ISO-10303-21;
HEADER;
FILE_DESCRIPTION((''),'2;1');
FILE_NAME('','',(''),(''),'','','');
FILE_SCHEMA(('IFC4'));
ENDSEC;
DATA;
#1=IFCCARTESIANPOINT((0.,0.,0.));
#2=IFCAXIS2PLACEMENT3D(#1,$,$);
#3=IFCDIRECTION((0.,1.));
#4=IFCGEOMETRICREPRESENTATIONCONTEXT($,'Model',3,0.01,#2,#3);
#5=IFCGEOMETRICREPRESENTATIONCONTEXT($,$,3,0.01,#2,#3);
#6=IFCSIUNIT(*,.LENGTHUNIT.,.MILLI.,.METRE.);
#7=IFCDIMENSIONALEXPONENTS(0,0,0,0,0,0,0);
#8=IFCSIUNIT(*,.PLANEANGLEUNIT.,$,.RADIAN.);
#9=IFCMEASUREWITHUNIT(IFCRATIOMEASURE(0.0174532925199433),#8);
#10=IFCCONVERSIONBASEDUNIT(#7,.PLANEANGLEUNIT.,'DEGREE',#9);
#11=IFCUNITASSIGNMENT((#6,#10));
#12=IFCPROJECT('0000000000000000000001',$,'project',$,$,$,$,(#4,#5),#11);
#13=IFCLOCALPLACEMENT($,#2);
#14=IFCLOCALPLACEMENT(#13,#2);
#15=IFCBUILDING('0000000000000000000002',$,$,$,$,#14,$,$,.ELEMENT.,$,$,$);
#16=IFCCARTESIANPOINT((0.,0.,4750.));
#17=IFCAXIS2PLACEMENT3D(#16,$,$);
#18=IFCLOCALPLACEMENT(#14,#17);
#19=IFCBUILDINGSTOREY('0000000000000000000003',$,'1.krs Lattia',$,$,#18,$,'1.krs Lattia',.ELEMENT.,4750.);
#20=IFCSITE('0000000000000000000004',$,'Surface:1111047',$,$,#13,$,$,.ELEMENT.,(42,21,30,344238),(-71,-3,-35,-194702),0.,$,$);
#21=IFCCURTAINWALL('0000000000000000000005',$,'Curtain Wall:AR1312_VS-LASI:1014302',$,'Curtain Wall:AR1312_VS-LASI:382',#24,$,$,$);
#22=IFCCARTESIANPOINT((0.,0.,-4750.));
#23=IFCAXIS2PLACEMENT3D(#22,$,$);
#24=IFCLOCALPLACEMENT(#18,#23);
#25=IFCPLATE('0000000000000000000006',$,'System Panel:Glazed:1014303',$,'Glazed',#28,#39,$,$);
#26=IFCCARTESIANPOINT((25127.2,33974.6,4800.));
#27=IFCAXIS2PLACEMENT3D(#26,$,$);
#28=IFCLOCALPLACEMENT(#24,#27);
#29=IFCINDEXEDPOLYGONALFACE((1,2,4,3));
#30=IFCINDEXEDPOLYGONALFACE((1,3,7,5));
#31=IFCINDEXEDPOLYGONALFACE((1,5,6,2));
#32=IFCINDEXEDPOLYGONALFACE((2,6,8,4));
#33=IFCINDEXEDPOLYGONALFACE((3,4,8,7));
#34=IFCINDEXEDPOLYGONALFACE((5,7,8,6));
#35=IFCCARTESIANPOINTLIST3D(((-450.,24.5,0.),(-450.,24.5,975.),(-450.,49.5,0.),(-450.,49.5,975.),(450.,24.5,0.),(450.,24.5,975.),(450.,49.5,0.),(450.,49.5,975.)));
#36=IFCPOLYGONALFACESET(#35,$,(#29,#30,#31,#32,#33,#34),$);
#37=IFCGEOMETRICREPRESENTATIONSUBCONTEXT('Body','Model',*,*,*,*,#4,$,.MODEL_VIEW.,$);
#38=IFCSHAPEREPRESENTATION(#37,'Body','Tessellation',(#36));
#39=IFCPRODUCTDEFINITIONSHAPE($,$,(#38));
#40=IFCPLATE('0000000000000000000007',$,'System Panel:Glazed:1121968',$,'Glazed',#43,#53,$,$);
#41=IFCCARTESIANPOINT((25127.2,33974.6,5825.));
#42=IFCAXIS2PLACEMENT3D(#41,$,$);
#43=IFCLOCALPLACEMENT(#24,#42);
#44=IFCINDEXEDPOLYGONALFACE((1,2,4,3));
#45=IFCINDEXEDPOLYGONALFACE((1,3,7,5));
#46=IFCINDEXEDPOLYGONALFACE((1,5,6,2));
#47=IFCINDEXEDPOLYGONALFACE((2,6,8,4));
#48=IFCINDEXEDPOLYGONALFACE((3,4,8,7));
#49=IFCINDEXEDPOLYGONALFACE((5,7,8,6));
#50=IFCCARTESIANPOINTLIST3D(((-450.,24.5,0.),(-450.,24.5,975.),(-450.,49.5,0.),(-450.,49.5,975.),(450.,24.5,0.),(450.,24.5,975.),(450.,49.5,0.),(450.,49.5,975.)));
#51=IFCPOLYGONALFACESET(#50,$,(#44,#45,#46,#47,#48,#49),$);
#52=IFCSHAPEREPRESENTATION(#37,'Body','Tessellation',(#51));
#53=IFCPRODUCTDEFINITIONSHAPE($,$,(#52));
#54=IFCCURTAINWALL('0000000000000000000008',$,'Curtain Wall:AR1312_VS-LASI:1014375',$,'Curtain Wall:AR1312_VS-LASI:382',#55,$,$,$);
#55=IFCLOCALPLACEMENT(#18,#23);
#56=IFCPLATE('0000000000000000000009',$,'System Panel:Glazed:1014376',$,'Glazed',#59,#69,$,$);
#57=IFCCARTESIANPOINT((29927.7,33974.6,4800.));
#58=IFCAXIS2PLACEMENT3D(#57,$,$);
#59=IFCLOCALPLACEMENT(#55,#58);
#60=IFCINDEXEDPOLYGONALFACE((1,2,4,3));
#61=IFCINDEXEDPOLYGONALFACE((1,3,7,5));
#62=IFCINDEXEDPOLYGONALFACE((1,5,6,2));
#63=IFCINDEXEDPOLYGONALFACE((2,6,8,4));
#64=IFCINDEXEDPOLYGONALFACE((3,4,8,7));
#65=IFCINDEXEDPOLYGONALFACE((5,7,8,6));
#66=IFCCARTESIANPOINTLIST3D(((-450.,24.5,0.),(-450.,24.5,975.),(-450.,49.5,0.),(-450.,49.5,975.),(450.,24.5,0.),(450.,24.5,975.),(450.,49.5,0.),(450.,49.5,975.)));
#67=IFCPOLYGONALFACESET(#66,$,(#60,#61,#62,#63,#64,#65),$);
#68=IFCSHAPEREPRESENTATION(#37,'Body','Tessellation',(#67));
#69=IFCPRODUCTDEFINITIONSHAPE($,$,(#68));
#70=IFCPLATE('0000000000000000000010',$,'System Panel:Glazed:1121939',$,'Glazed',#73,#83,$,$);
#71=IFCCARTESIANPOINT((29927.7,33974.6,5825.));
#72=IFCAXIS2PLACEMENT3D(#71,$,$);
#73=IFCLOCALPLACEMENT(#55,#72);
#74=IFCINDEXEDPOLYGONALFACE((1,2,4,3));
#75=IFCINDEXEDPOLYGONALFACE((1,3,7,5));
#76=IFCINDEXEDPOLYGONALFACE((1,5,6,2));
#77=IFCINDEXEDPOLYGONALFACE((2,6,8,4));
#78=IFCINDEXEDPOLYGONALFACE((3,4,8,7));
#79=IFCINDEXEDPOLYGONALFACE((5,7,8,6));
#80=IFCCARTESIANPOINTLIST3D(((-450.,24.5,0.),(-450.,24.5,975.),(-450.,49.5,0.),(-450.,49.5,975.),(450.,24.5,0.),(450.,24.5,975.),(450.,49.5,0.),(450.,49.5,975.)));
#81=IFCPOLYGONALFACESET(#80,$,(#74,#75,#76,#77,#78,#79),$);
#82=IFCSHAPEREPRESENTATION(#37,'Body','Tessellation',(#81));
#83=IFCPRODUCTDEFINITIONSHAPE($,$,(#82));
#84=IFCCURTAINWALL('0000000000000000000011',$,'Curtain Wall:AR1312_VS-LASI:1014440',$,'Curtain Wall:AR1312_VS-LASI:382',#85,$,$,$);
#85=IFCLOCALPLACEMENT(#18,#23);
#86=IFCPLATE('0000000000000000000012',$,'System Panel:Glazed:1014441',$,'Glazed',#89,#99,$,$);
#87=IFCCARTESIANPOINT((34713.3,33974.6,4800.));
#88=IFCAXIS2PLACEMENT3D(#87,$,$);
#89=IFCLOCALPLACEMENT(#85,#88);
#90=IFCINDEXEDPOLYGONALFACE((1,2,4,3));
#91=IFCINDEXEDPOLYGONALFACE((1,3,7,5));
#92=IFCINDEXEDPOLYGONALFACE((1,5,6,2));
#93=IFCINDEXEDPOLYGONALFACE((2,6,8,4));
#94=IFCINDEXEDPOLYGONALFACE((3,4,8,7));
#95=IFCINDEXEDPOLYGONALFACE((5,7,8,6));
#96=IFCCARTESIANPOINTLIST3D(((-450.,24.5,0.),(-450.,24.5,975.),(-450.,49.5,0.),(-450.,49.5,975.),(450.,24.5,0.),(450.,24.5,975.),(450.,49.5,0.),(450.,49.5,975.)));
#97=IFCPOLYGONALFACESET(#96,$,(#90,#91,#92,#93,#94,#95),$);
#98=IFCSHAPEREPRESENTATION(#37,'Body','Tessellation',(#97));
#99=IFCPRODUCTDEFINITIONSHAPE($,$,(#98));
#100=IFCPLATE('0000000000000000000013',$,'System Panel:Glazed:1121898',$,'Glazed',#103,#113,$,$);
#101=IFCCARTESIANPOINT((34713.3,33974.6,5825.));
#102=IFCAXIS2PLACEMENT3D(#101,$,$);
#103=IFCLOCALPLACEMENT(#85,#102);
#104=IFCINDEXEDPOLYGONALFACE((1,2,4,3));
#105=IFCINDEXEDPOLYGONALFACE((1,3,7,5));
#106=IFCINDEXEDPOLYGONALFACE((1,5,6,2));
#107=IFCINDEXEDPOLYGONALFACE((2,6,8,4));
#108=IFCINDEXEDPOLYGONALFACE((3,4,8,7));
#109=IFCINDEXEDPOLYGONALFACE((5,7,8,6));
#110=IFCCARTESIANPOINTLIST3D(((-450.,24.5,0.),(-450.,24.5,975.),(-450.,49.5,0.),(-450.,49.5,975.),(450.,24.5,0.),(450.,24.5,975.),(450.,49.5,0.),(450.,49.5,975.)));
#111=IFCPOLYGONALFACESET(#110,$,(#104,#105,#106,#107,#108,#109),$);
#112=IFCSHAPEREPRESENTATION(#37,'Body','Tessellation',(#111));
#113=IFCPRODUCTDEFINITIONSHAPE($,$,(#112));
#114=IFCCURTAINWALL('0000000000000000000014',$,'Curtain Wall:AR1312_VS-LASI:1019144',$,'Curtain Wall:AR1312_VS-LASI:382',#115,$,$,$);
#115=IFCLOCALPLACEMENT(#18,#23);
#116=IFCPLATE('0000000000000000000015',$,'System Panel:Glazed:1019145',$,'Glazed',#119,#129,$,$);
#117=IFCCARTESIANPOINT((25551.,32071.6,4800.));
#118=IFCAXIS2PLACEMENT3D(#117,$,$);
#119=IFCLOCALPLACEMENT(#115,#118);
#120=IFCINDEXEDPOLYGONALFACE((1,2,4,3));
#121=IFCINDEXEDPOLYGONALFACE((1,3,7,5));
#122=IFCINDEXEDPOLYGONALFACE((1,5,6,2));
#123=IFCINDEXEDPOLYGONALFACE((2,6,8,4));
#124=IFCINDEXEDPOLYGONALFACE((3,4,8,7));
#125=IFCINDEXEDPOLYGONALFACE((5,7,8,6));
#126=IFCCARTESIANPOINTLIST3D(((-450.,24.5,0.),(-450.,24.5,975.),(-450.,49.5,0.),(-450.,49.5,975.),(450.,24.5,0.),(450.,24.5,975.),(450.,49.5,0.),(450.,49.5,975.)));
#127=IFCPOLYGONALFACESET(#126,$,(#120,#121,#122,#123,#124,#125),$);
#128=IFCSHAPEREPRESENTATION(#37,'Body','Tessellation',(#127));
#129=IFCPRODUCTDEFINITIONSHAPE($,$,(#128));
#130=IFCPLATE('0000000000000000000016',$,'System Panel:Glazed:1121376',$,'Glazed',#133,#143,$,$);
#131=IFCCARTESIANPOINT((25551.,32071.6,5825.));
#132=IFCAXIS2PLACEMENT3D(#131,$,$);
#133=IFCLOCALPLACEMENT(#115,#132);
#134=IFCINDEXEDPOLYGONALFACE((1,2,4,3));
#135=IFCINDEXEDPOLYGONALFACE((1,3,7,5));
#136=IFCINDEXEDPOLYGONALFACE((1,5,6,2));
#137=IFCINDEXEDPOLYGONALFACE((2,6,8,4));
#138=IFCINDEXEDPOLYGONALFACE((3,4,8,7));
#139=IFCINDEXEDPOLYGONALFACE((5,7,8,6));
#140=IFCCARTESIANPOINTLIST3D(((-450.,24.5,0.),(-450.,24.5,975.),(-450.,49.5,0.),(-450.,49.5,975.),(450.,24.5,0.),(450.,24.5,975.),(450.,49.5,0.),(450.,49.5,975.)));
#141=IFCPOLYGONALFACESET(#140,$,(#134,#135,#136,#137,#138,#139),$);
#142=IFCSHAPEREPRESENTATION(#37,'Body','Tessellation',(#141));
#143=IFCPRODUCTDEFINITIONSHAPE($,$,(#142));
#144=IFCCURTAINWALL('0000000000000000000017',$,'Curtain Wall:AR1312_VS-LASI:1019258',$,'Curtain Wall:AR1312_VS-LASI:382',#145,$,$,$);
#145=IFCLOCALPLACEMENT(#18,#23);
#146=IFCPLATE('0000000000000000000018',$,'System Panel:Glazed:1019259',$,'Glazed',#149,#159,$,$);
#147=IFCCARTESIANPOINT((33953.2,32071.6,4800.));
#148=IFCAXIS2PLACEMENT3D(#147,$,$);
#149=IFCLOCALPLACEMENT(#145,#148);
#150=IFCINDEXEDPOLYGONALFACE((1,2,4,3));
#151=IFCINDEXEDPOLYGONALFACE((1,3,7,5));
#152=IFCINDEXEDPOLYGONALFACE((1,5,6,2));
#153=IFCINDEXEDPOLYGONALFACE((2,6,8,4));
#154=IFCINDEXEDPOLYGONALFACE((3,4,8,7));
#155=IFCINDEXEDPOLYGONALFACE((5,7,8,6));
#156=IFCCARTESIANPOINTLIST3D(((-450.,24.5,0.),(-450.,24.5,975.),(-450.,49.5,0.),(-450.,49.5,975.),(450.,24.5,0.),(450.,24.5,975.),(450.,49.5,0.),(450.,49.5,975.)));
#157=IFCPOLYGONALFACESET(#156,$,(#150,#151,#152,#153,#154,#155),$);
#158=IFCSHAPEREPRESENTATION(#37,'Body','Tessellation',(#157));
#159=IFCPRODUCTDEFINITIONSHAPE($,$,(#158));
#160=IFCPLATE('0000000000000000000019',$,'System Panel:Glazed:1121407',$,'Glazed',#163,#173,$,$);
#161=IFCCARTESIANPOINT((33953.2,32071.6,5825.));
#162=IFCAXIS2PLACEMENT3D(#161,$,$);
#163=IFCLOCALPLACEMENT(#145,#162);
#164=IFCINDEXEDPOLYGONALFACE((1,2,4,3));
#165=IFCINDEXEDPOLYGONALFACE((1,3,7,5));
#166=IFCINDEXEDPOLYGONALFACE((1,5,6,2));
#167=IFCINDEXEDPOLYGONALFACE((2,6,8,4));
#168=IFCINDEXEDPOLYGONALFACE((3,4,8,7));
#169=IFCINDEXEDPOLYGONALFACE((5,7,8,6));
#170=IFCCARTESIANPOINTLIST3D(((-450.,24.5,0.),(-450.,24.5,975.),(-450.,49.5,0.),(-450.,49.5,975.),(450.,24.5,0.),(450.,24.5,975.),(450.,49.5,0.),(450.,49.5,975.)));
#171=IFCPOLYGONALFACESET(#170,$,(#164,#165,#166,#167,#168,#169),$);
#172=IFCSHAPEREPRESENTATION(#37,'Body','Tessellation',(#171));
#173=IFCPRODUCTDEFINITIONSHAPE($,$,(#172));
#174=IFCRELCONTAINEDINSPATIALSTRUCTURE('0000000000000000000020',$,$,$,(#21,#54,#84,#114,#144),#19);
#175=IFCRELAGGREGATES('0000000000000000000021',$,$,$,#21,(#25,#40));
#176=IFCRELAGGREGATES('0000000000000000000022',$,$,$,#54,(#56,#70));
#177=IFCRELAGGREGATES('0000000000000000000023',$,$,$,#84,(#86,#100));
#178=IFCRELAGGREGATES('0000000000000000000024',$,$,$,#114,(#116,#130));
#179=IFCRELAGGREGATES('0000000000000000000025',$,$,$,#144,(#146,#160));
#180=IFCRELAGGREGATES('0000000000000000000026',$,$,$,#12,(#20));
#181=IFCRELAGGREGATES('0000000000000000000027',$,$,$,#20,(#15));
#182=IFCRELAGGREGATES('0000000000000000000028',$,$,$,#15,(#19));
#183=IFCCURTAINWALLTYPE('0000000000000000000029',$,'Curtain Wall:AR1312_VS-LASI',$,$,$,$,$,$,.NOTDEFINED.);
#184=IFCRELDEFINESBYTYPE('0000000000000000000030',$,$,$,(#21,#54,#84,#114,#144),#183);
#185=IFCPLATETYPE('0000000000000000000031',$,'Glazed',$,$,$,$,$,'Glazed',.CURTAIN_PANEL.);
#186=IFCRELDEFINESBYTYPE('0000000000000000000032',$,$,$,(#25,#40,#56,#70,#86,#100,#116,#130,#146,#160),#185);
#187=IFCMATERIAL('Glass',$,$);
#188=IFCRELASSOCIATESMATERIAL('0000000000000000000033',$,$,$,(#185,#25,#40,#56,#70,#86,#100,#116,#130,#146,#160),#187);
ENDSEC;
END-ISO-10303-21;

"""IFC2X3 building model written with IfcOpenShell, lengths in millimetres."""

from ifc_helpers import new_model, entity, si_unit, converted_unit, direction, frame, origin, origin_2d_with_axis, place, context, subcontext, project, spatial, rectangle, extrude, source, transform, mapped, material, type_object, type_shapes, element, aggregate, save


model = new_model("IFC2X3")

# Units and contexts
model_context = context("Model", 3, precision=0.01, world=origin(), true_north=direction((0.0, 1.0)))
context_of_model = context(None, 3, precision=0.01, world=origin(), true_north=direction((0.0, 1.0)))
body_context = subcontext(model_context, "Body", "Model", "MODEL_VIEW")
ifc_project = project(units=[si_unit("LENGTHUNIT", "METRE", prefix="MILLI"), converted_unit("PLANEANGLEUNIT", "DEGREE", entity("IfcRatioMeasure", 0.0174532925199433), si_unit("PLANEANGLEUNIT", "RADIAN"), dimensions=[0, 0, 0, 0, 0, 0, 0])], contexts=[model_context, context_of_model])

# Site, building, storey
site_placement = place(None, origin())
site = spatial("IfcSite", under=ifc_project, at=site_placement, Name="Surface:1111047", CompositionType="ELEMENT", RefLatitude=(42, 21, 30, 344238), RefLongitude=(-71, -3, -35, -194702), RefElevation=0.0)
building_placement = place(site_placement, origin())
building = spatial("IfcBuilding", under=site, at=building_placement, CompositionType="ELEMENT")
storey_placement = place(building_placement, frame((0.0, 0.0, 4750.0)))
storey = spatial("IfcBuildingStorey", under=building, at=storey_placement, Name="1.krs Lattia", LongName="1.krs Lattia", CompositionType="ELEMENT", Elevation=4750.0)

# Curtain walls, plates
curtain_wall_type = type_object("IfcCurtainWallType", Name="Curtain Wall:AR1312_VS-LASI", PredefinedType="NOTDEFINED")
curtain_wall_1_placement = place(storey_placement, frame((0.0, 0.0, -4750.0)))
curtain_wall_1 = element("IfcCurtainWall", 1, at=curtain_wall_1_placement, inside=storey, type_object=curtain_wall_type, Name="Curtain Wall:AR1312_VS-LASI:1014302", ObjectType="Curtain Wall:AR1312_VS-LASI:382")
ifc_material_1 = material(Name="Glass")
plate_type = type_object("IfcPlateType", Name="Glazed", ElementType="Glazed", PredefinedType="CURTAIN_PANEL", material=ifc_material_1)
shared_shape_1 = source(origin(), body_context, "Body", "SweptSolid", [
    extrude(rectangle(XDim=25.0, YDim=900.0, at=origin_2d_with_axis()), frame((0.0, 37.0, 0.0), z_axis=(0.0, 0.0, 1.0), x_axis=(0.0, 1.0, 0.0)), (0.0, 0.0, 1.0), 975.0),
])
type_shapes(plate_type, [shared_shape_1])
plate_1_placement = place(curtain_wall_1_placement, frame((25127.2, 33974.6, 4800.0)))
plate_1 = element("IfcPlate", 2, at=plate_1_placement, type_object=plate_type, material=ifc_material_1, Name="System Panel:Glazed:1014303", ObjectType="Glazed", context=body_context, shape_type="MappedRepresentation", body=[
    mapped(shared_shape_1, transform((0.0, 0.0, 0.0), scale=1.0)),
])
plate_2_placement = place(curtain_wall_1_placement, frame((25127.2, 33974.6, 5825.0)))
plate_2 = element("IfcPlate", 3, at=plate_2_placement, type_object=plate_type, material=ifc_material_1, Name="System Panel:Glazed:1121968", ObjectType="Glazed", context=body_context, shape_type="MappedRepresentation", body=[
    mapped(shared_shape_1, transform((0.0, 0.0, 0.0), scale=1.0)),
])
aggregate(curtain_wall_1, [plate_1, plate_2])
curtain_wall_2_placement = place(storey_placement, frame((0.0, 0.0, -4750.0)))
curtain_wall_2 = element("IfcCurtainWall", 4, at=curtain_wall_2_placement, inside=storey, type_object=curtain_wall_type, Name="Curtain Wall:AR1312_VS-LASI:1014375", ObjectType="Curtain Wall:AR1312_VS-LASI:382")
plate_3_placement = place(curtain_wall_2_placement, frame((29927.7, 33974.6, 4800.0)))
plate_3 = element("IfcPlate", 5, at=plate_3_placement, type_object=plate_type, material=ifc_material_1, Name="System Panel:Glazed:1014376", ObjectType="Glazed", context=body_context, shape_type="MappedRepresentation", body=[
    mapped(shared_shape_1, transform((0.0, 0.0, 0.0), scale=1.0)),
])
plate_4_placement = place(curtain_wall_2_placement, frame((29927.7, 33974.6, 5825.0)))
plate_4 = element("IfcPlate", 6, at=plate_4_placement, type_object=plate_type, material=ifc_material_1, Name="System Panel:Glazed:1121939", ObjectType="Glazed", context=body_context, shape_type="MappedRepresentation", body=[
    mapped(shared_shape_1, transform((0.0, 0.0, 0.0), scale=1.0)),
])
aggregate(curtain_wall_2, [plate_3, plate_4])
curtain_wall_3_placement = place(storey_placement, frame((0.0, 0.0, -4750.0)))
curtain_wall_3 = element("IfcCurtainWall", 7, at=curtain_wall_3_placement, inside=storey, type_object=curtain_wall_type, Name="Curtain Wall:AR1312_VS-LASI:1014440", ObjectType="Curtain Wall:AR1312_VS-LASI:382")
plate_5_placement = place(curtain_wall_3_placement, frame((34713.3, 33974.6, 4800.0)))
plate_5 = element("IfcPlate", 8, at=plate_5_placement, type_object=plate_type, material=ifc_material_1, Name="System Panel:Glazed:1014441", ObjectType="Glazed", context=body_context, shape_type="MappedRepresentation", body=[
    mapped(shared_shape_1, transform((0.0, 0.0, 0.0), scale=1.0)),
])
plate_6_placement = place(curtain_wall_3_placement, frame((34713.3, 33974.6, 5825.0)))
plate_6 = element("IfcPlate", 9, at=plate_6_placement, type_object=plate_type, material=ifc_material_1, Name="System Panel:Glazed:1121898", ObjectType="Glazed", context=body_context, shape_type="MappedRepresentation", body=[
    mapped(shared_shape_1, transform((0.0, 0.0, 0.0), scale=1.0)),
])
aggregate(curtain_wall_3, [plate_5, plate_6])
curtain_wall_4_placement = place(storey_placement, frame((0.0, 0.0, -4750.0)))
curtain_wall_4 = element("IfcCurtainWall", 10, at=curtain_wall_4_placement, inside=storey, type_object=curtain_wall_type, Name="Curtain Wall:AR1312_VS-LASI:1019144", ObjectType="Curtain Wall:AR1312_VS-LASI:382")
plate_7_placement = place(curtain_wall_4_placement, frame((25551.0, 32071.6, 4800.0)))
plate_7 = element("IfcPlate", 11, at=plate_7_placement, type_object=plate_type, material=ifc_material_1, Name="System Panel:Glazed:1019145", ObjectType="Glazed", context=body_context, shape_type="MappedRepresentation", body=[
    mapped(shared_shape_1, transform((0.0, 0.0, 0.0), scale=1.0)),
])
plate_8_placement = place(curtain_wall_4_placement, frame((25551.0, 32071.6, 5825.0)))
plate_8 = element("IfcPlate", 12, at=plate_8_placement, type_object=plate_type, material=ifc_material_1, Name="System Panel:Glazed:1121376", ObjectType="Glazed", context=body_context, shape_type="MappedRepresentation", body=[
    mapped(shared_shape_1, transform((0.0, 0.0, 0.0), scale=1.0)),
])
aggregate(curtain_wall_4, [plate_7, plate_8])
curtain_wall_5_placement = place(storey_placement, frame((0.0, 0.0, -4750.0)))
curtain_wall_5 = element("IfcCurtainWall", 13, at=curtain_wall_5_placement, inside=storey, type_object=curtain_wall_type, Name="Curtain Wall:AR1312_VS-LASI:1019258", ObjectType="Curtain Wall:AR1312_VS-LASI:382")
plate_9_placement = place(curtain_wall_5_placement, frame((33953.2, 32071.6, 4800.0)))
plate_9 = element("IfcPlate", 14, at=plate_9_placement, type_object=plate_type, material=ifc_material_1, Name="System Panel:Glazed:1019259", ObjectType="Glazed", context=body_context, shape_type="MappedRepresentation", body=[
    mapped(shared_shape_1, transform((0.0, 0.0, 0.0), scale=1.0)),
])
plate_10_placement = place(curtain_wall_5_placement, frame((33953.2, 32071.6, 5825.0)))
plate_10 = element("IfcPlate", 15, at=plate_10_placement, type_object=plate_type, material=ifc_material_1, Name="System Panel:Glazed:1121407", ObjectType="Glazed", context=body_context, shape_type="MappedRepresentation", body=[
    mapped(shared_shape_1, transform((0.0, 0.0, 0.0), scale=1.0)),
])
aggregate(curtain_wall_5, [plate_9, plate_10])

save(model, "model.ifc")
